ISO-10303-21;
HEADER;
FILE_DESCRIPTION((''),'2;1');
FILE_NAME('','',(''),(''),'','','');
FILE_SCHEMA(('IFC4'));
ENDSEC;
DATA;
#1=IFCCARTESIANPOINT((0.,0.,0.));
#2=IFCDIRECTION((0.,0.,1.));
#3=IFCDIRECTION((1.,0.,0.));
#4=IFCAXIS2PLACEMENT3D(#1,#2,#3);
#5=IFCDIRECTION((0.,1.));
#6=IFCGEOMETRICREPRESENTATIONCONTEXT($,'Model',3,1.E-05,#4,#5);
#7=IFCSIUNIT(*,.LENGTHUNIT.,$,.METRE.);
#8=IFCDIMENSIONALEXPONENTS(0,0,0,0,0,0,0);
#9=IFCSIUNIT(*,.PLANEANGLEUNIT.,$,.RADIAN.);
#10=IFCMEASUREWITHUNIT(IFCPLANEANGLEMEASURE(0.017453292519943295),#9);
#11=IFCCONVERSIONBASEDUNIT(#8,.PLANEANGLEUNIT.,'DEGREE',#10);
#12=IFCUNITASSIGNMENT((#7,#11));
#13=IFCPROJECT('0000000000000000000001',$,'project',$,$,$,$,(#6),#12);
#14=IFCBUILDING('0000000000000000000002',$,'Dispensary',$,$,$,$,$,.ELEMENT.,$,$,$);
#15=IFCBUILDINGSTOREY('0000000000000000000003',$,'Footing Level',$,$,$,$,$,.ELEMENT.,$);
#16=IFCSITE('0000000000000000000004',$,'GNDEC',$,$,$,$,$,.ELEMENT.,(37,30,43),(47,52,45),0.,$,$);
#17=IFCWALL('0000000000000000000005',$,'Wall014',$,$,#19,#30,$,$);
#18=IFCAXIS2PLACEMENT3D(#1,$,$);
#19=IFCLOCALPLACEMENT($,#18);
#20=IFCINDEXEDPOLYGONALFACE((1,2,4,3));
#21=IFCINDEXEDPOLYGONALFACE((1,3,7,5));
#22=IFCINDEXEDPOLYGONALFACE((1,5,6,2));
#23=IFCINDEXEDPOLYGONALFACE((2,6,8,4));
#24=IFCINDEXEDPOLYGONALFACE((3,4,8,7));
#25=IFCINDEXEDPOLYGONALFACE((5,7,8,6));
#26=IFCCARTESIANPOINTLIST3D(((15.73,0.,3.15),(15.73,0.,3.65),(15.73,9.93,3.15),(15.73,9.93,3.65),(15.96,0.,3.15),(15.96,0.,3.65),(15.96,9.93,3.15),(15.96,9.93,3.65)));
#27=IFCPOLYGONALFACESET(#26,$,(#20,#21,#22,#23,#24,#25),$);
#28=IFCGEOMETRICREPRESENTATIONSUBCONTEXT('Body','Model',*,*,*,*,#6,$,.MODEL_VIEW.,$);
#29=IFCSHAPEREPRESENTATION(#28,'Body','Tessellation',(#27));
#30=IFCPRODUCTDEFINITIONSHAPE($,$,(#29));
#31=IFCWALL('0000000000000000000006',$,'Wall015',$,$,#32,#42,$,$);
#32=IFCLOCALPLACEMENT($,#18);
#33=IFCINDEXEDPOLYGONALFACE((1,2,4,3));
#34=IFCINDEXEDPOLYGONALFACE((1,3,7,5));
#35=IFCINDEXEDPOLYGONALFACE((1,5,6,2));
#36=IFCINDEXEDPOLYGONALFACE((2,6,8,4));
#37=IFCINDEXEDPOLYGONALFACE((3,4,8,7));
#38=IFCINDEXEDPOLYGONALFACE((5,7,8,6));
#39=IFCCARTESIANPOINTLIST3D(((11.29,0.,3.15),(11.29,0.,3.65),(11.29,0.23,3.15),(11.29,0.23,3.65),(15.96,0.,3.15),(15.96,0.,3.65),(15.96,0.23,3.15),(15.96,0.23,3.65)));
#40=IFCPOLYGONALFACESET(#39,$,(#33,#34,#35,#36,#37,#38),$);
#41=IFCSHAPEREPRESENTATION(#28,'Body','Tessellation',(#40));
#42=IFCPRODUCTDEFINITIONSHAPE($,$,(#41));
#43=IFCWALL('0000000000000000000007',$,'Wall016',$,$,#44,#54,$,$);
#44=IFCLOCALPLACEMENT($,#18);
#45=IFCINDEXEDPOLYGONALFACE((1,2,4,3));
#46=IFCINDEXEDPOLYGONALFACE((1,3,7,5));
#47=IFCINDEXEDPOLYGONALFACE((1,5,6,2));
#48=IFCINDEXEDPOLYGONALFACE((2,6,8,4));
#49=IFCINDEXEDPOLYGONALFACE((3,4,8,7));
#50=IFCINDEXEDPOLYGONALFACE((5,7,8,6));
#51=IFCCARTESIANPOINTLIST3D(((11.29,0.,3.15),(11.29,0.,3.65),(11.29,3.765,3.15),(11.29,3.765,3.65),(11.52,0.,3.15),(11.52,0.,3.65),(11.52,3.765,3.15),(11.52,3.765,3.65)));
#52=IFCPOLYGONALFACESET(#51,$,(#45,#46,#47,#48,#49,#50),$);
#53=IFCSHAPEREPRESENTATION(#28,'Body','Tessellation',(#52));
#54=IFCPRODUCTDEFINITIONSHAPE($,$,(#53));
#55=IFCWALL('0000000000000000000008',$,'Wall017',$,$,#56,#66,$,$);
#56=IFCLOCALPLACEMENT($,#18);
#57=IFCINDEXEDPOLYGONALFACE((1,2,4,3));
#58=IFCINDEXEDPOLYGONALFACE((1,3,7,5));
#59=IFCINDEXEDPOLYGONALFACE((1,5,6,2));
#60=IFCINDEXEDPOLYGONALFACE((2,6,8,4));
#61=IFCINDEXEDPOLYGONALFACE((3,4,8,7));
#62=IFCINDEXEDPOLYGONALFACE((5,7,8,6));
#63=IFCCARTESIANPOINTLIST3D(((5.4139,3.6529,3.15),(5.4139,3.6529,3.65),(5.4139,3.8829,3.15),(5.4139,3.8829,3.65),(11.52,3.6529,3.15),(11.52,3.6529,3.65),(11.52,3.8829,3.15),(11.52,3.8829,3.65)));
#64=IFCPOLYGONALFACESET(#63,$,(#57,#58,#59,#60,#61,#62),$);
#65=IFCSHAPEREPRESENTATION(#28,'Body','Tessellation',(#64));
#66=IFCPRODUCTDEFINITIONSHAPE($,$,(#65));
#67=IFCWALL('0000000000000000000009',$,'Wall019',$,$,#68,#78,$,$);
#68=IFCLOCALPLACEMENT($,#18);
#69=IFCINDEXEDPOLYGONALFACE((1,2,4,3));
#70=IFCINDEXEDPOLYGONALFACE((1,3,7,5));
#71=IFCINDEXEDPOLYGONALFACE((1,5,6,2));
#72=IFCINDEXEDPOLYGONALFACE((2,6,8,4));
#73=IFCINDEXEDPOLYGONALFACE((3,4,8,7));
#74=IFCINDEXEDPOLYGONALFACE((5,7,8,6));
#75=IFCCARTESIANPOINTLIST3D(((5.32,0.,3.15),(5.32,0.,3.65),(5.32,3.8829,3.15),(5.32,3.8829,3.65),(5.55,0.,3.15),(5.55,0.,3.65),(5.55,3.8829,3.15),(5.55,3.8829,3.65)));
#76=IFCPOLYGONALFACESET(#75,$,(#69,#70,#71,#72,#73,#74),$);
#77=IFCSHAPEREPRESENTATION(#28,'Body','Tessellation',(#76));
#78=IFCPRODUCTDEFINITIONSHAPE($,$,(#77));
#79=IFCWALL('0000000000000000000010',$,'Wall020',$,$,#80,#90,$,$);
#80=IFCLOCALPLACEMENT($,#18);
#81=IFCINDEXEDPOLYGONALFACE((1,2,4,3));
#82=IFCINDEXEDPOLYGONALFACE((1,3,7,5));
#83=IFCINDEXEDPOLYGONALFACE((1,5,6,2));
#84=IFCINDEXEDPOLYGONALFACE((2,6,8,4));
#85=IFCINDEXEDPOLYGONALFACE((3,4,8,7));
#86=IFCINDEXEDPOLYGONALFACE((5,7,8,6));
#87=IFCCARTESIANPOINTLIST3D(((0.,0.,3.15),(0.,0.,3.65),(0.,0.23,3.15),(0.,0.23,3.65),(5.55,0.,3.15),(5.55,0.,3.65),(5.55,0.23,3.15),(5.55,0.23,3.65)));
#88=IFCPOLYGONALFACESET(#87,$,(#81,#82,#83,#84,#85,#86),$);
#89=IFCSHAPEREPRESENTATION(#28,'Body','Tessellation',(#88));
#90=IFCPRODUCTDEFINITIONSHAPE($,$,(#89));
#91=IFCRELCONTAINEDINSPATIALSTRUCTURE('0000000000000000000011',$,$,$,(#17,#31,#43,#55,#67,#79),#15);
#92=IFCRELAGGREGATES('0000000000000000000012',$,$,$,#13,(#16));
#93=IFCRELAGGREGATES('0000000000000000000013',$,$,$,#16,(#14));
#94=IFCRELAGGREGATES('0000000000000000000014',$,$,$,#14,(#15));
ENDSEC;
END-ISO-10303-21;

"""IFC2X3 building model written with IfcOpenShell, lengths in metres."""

from ifc_helpers import new_model, entity, si_unit, converted_unit, direction, frame, frame_2d, origin_with_axes, origin_2d_with_axis, place, context, subcontext, project, spatial, rectangle, extrude, element, save


model = new_model("IFC2X3")

# Units and contexts
model_context = context("Model", 3, precision=1e-05, world=origin_with_axes(), true_north=direction((0.0, 1.0)))
body_context = subcontext(model_context, "Body", "Model", "MODEL_VIEW")
ifc_project = project(units=[si_unit("LENGTHUNIT", "METRE"), converted_unit("PLANEANGLEUNIT", "DEGREE", entity("IfcPlaneAngleMeasure", 0.017453292519943295), si_unit("PLANEANGLEUNIT", "RADIAN"), dimensions=[0, 0, 0, 0, 0, 0, 0])], contexts=[model_context])

# Site, building, storey
site = spatial("IfcSite", under=ifc_project, Name="GNDEC", CompositionType="ELEMENT", RefLatitude=(37, 30, 43), RefLongitude=(47, 52, 45), RefElevation=0.0)
building = spatial("IfcBuilding", under=site, Name="Dispensary", CompositionType="ELEMENT")
storey = spatial("IfcBuildingStorey", under=building, Name="Footing Level", CompositionType="ELEMENT")

# Shared definitions
placement = place(None, origin_with_axes())

# Walls
element("IfcWall", 1, at=placement, inside=storey, Name="Wall014", context=body_context, shape_type="SweptSolid", body=[
    extrude(rectangle(XDim=9.93, YDim=0.23, at=frame_2d((0.0, 0.0), x_axis=(0.0, 1.0))), frame((15.845, 4.965, 3.15), z_axis=(0.0, 0.0, 1.0), x_axis=(1.0, 0.0, 0.0)), (0.0, 0.0, 1.0), 0.5),
])
element("IfcWall", 2, at=placement, inside=storey, Name="Wall015", context=body_context, shape_type="SweptSolid", body=[
    extrude(rectangle(XDim=4.67, YDim=0.23, at=frame_2d((0.0, 0.0), x_axis=(1.0, 0.0))), frame((13.625, 0.115, 3.15), z_axis=(0.0, 0.0, 1.0), x_axis=(1.0, 0.0, 0.0)), (0.0, 0.0, 1.0), 0.5),
])
element("IfcWall", 3, at=placement, inside=storey, Name="Wall016", context=body_context, shape_type="SweptSolid", body=[
    extrude(rectangle(XDim=3.765, YDim=0.23, at=frame_2d((0.0, 0.0), x_axis=(0.0, -1.0))), frame((11.405, 1.8825, 3.15), z_axis=(0.0, 0.0, 1.0), x_axis=(1.0, 0.0, 0.0)), (0.0, 0.0, 1.0), 0.5),
])
element("IfcWall", 4, at=placement, inside=storey, Name="Wall017", context=body_context, shape_type="SweptSolid", body=[
    extrude(rectangle(XDim=6.1061, YDim=0.23, at=frame_2d((0.0, 0.0), x_axis=(1.0, 0.0))), frame((8.4669, 3.7679, 3.15), z_axis=(0.0, 0.0, 1.0), x_axis=(1.0, 0.0, 0.0)), (0.0, 0.0, 1.0), 0.5),
])
element("IfcWall", 5, at=placement, inside=storey, Name="Wall019", context=body_context, shape_type="SweptSolid", body=[
    extrude(rectangle(XDim=3.8829, YDim=0.23, at=frame_2d((0.0, 0.0), x_axis=(0.0, 1.0))), frame((5.435, 1.9414, 3.15), z_axis=(0.0, 0.0, 1.0), x_axis=(1.0, 0.0, 0.0)), (0.0, 0.0, 1.0), 0.5),
])
element("IfcWall", 6, at=placement, inside=storey, Name="Wall020", context=body_context, shape_type="SweptSolid", body=[
    extrude(rectangle(XDim=5.55, YDim=0.23, at=origin_2d_with_axis()), frame((2.775, 0.115, 3.15), z_axis=(0.0, 0.0, 1.0), x_axis=(1.0, 0.0, 0.0)), (0.0, 0.0, 1.0), 0.5),
])

save(model, "model.ifc")
